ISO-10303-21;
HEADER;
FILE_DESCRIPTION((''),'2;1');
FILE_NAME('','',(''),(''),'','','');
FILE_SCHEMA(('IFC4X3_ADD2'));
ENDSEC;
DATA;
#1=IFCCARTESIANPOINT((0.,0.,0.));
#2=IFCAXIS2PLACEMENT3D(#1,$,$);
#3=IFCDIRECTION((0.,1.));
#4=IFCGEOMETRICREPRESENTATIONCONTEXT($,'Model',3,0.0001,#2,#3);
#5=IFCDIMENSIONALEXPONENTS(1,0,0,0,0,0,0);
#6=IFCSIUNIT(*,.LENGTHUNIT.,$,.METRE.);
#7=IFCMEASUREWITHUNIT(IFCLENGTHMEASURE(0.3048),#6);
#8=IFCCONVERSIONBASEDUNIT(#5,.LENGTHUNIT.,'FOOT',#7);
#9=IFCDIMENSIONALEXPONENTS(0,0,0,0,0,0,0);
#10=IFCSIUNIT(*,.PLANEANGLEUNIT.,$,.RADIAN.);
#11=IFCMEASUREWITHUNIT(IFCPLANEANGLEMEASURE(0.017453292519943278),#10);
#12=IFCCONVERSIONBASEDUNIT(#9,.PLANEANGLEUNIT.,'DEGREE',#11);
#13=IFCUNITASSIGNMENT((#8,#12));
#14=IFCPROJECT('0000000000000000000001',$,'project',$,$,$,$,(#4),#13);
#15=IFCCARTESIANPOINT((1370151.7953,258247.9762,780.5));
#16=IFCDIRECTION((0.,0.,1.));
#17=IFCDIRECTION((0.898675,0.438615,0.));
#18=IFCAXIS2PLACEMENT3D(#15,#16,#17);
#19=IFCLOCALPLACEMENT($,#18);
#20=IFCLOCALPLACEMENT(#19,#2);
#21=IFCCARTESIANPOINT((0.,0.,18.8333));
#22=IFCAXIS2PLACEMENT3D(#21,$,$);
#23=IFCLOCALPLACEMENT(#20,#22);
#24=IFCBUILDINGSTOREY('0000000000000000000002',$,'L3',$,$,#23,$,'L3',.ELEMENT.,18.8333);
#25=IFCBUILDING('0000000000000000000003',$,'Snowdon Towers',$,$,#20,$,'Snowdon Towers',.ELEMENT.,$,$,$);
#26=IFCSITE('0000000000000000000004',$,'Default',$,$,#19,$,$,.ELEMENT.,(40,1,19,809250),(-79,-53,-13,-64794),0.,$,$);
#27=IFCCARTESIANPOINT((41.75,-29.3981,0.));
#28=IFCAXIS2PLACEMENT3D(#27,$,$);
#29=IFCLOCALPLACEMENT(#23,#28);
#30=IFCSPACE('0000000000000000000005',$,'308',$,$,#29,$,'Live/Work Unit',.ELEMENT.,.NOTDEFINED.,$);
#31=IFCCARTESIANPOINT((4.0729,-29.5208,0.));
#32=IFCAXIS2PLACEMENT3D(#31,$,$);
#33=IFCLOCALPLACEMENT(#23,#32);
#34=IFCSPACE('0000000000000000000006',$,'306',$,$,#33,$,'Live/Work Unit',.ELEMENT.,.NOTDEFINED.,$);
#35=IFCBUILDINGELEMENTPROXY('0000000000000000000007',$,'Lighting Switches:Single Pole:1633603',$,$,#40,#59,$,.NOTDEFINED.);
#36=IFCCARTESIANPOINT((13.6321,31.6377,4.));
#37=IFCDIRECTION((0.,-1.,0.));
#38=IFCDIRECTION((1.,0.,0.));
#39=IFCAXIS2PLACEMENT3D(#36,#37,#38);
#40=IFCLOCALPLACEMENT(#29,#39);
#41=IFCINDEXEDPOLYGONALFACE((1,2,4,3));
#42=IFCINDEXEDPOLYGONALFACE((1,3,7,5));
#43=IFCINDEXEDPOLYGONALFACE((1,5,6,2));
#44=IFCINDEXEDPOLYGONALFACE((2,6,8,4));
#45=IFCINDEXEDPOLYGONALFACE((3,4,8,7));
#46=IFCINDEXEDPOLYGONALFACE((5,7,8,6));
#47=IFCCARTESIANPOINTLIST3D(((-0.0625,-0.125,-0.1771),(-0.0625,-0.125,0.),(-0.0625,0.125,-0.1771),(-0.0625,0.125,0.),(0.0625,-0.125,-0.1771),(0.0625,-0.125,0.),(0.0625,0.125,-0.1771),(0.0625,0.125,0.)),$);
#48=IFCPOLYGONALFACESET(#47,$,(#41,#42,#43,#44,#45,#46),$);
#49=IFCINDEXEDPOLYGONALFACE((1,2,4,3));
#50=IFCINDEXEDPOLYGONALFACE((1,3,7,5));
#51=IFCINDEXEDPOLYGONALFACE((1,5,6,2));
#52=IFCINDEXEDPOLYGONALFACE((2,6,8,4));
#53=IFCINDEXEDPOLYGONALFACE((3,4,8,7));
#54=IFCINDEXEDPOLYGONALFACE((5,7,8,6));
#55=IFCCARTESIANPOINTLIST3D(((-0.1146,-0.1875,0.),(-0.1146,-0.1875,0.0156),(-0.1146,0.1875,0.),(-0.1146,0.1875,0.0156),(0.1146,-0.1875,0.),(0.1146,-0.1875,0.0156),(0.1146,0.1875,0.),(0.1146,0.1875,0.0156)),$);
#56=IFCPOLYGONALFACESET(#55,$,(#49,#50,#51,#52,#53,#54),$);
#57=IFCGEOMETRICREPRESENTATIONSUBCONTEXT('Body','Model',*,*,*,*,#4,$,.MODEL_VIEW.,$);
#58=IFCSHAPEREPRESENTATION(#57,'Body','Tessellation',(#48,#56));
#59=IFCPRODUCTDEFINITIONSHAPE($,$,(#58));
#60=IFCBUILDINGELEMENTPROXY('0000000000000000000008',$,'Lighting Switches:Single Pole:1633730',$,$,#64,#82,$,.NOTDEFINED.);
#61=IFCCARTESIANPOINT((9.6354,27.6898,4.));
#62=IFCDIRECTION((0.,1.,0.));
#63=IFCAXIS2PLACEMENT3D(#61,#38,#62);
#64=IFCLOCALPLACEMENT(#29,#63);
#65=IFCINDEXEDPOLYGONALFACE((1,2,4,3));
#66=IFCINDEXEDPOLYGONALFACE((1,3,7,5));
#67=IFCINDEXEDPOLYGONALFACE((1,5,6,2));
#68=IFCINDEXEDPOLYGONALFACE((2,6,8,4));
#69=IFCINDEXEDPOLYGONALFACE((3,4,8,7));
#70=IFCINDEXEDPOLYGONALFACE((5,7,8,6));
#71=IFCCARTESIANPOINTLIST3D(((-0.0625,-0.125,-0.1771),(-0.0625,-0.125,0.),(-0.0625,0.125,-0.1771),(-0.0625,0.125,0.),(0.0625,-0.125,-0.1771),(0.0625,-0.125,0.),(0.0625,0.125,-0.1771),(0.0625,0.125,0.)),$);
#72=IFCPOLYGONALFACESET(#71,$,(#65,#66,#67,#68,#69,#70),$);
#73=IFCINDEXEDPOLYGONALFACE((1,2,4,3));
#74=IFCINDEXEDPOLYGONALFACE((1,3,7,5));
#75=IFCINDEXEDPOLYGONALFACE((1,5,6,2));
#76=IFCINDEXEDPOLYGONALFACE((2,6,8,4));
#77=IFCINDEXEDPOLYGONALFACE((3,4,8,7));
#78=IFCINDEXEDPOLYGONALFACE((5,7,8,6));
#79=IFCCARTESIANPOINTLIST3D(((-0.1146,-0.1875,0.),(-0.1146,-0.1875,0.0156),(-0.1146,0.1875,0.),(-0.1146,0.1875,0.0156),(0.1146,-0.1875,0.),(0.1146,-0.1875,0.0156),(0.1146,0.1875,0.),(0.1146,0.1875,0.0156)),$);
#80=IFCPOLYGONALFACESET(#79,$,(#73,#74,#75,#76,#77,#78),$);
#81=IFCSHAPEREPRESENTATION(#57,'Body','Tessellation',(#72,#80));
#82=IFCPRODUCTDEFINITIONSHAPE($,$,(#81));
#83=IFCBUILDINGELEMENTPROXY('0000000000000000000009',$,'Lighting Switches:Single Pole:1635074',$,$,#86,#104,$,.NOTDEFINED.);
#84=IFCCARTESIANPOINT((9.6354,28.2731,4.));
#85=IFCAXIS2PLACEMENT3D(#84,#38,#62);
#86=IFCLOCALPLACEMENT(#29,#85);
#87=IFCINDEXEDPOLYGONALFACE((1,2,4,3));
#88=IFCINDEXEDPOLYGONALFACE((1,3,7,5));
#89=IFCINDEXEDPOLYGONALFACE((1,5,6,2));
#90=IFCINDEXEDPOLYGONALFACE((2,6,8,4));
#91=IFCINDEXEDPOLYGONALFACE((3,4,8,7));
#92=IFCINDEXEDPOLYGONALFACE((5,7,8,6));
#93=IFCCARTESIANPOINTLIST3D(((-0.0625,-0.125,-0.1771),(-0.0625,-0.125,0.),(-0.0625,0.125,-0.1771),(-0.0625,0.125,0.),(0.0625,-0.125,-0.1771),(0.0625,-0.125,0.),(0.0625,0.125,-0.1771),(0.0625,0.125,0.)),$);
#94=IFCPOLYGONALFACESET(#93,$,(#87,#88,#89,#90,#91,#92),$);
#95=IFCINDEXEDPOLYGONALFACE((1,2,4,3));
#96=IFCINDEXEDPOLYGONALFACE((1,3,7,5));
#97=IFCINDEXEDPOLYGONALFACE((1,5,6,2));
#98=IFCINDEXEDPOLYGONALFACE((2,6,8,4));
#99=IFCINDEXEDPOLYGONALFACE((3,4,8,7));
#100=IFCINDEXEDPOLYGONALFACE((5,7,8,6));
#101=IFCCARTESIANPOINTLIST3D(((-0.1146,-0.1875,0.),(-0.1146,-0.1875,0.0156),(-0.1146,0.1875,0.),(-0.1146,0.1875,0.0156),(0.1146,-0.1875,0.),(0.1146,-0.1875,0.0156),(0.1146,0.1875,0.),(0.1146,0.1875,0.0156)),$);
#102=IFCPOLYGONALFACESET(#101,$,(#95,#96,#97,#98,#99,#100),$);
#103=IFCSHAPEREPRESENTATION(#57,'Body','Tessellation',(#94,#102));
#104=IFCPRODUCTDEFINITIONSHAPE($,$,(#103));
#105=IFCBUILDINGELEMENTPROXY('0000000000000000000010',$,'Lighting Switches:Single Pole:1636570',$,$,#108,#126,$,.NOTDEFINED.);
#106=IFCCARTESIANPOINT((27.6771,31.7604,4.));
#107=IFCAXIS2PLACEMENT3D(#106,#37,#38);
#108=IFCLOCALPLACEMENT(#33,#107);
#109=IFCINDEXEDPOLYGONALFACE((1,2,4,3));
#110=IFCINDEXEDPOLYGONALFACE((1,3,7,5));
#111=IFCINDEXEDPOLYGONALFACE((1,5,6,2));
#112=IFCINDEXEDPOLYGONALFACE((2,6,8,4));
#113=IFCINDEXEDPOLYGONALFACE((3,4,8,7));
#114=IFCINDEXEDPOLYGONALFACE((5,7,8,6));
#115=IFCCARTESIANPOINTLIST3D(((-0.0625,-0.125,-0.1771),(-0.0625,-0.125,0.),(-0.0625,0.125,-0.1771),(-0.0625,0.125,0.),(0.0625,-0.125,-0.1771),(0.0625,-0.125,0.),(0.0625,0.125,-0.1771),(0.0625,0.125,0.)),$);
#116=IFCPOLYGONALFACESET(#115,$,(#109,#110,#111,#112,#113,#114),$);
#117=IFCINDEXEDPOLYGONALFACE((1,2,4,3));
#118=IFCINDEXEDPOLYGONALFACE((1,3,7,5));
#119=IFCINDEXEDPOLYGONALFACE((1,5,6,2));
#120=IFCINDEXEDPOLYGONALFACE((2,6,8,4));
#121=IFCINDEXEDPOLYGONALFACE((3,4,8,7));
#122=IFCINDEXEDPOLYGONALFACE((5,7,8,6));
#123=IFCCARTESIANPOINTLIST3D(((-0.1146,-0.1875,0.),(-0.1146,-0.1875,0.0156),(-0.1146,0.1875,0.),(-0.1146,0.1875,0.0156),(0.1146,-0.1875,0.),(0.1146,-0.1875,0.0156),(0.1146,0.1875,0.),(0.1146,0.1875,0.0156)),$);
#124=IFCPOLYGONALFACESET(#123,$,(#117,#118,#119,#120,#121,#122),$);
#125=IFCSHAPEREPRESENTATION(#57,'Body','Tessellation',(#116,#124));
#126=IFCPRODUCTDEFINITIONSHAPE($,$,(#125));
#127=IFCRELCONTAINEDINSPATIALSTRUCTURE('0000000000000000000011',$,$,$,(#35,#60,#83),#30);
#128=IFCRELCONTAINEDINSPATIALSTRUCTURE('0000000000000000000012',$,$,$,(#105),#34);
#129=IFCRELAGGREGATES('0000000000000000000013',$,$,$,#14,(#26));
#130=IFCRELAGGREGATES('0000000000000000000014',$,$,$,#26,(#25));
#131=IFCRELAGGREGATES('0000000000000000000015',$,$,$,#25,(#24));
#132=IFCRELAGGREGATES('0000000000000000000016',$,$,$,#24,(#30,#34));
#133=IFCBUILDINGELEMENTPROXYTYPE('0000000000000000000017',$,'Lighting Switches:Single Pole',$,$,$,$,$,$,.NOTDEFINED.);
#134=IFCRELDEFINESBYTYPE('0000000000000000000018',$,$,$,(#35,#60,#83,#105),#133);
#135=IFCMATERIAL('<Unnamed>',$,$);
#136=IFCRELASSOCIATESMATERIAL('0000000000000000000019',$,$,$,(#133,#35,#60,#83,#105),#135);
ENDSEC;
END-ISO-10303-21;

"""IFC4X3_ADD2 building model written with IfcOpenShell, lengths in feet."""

from ifc_helpers import new_model, entity, si_unit, converted_unit, direction, frame, frame_2d, origin, origin_2d_with_axis, place, context, subcontext, project, spatial, rectangle, extrude, source, transform, mapped, material, type_object, type_shapes, element, save


model = new_model("IFC4X3_ADD2")

# Units and contexts
model_context = context("Model", 3, precision=0.0001, world=origin(), true_north=direction((0.0, 1.0)))
body_context = subcontext(model_context, "Body", "Model", "MODEL_VIEW")
ifc_project = project(units=[converted_unit("LENGTHUNIT", "FOOT", entity("IfcLengthMeasure", 0.3048), si_unit("LENGTHUNIT", "METRE"), dimensions=[1, 0, 0, 0, 0, 0, 0]), converted_unit("PLANEANGLEUNIT", "DEGREE", entity("IfcPlaneAngleMeasure", 0.017453292519943278), si_unit("PLANEANGLEUNIT", "RADIAN"), dimensions=[0, 0, 0, 0, 0, 0, 0])], contexts=[model_context])

# Site, building, storey
site_placement = place(None, frame((1370151.7953, 258247.9762, 780.5), z_axis=(0.0, 0.0, 1.0), x_axis=(0.898675, 0.438615, 0.0)))
site = spatial("IfcSite", under=ifc_project, at=site_placement, Name="Default", CompositionType="ELEMENT", RefLatitude=(40, 1, 19, 809250), RefLongitude=(-79, -53, -13, -64794), RefElevation=0.0)
building_placement = place(site_placement, origin())
building = spatial("IfcBuilding", under=site, at=building_placement, Name="Snowdon Towers", LongName="Snowdon Towers", CompositionType="ELEMENT")
storey_placement = place(building_placement, frame((0.0, 0.0, 18.8333)))
storey = spatial("IfcBuildingStorey", under=building, at=storey_placement, Name="L3", LongName="L3", CompositionType="ELEMENT", Elevation=18.8333)

# Shared definitions
space_1_placement = place(storey_placement, frame((41.75, -29.3981, 0.0)))
space_1 = spatial("IfcSpace", under=storey, at=space_1_placement, Name="308", LongName="Live/Work Unit", CompositionType="ELEMENT", PredefinedType="NOTDEFINED")

# Shared definitions
ifc_material_1 = material(Name="<Unnamed>")

# Shared definitions
space_2_placement = place(storey_placement, frame((4.0729, -29.5208, 0.0)))
space_2 = spatial("IfcSpace", under=storey, at=space_2_placement, Name="306", LongName="Live/Work Unit", CompositionType="ELEMENT", PredefinedType="NOTDEFINED")

# Building element proxies
building_element_proxy_type_1 = type_object("IfcBuildingElementProxyType", Name="Lighting Switches:Single Pole", PredefinedType="NOTDEFINED", material=ifc_material_1)
shared_shape_1 = source(origin(), body_context, "Body", "SweptSolid", [
    extrude(rectangle(XDim=0.125, YDim=0.25, at=origin_2d_with_axis()), frame((0.0, 0.0, -0.1771), z_axis=(0.0, 0.0, 1.0), x_axis=(-1.0, 0.0, 0.0)), (0.0, 0.0, 1.0), 0.1771),
    extrude(rectangle(XDim=0.2292, YDim=0.375, at=frame_2d((0.0, 0.0), x_axis=(1.0, 0.0))), frame((0.0, 0.0, 0.0), z_axis=(0.0, 0.0, 1.0), x_axis=(-1.0, 0.0, 0.0)), (0.0, 0.0, 1.0), 0.0156),
])
type_shapes(building_element_proxy_type_1, [shared_shape_1])
for number, where, z_axis, x_axis, name in (
    (1, (13.6321, 31.6377, 4.0), (0.0, -1.0, 0.0), (1.0, 0.0, 0.0), "Lighting Switches:Single Pole:1633603"),
    (2, (9.6354, 27.6898, 4.0), (1.0, 0.0, 0.0), (0.0, 1.0, 0.0), "Lighting Switches:Single Pole:1633730"),
    (3, (9.6354, 28.2731, 4.0), (1.0, 0.0, 0.0), (0.0, 1.0, 0.0), "Lighting Switches:Single Pole:1635074"),
):
    element("IfcBuildingElementProxy", number, at=place(space_1_placement, frame(where, z_axis=z_axis, x_axis=x_axis)), inside=space_1, type_object=building_element_proxy_type_1, material=ifc_material_1, Name=name, PredefinedType="NOTDEFINED", context=body_context, shape_type="MappedRepresentation", body=[
        mapped(shared_shape_1, transform((0.0, 0.0, 0.0), scale=1.0)),
    ])
proxy_1_placement = place(space_2_placement, frame((27.6771, 31.7604, 4.0), z_axis=(0.0, -1.0, 0.0), x_axis=(1.0, 0.0, 0.0)))
element("IfcBuildingElementProxy", 4, at=proxy_1_placement, inside=space_2, type_object=building_element_proxy_type_1, material=ifc_material_1, Name="Lighting Switches:Single Pole:1636570", PredefinedType="NOTDEFINED", context=body_context, shape_type="MappedRepresentation", body=[
    mapped(shared_shape_1, transform((0.0, 0.0, 0.0), scale=1.0)),
])

save(model, "model.ifc")
